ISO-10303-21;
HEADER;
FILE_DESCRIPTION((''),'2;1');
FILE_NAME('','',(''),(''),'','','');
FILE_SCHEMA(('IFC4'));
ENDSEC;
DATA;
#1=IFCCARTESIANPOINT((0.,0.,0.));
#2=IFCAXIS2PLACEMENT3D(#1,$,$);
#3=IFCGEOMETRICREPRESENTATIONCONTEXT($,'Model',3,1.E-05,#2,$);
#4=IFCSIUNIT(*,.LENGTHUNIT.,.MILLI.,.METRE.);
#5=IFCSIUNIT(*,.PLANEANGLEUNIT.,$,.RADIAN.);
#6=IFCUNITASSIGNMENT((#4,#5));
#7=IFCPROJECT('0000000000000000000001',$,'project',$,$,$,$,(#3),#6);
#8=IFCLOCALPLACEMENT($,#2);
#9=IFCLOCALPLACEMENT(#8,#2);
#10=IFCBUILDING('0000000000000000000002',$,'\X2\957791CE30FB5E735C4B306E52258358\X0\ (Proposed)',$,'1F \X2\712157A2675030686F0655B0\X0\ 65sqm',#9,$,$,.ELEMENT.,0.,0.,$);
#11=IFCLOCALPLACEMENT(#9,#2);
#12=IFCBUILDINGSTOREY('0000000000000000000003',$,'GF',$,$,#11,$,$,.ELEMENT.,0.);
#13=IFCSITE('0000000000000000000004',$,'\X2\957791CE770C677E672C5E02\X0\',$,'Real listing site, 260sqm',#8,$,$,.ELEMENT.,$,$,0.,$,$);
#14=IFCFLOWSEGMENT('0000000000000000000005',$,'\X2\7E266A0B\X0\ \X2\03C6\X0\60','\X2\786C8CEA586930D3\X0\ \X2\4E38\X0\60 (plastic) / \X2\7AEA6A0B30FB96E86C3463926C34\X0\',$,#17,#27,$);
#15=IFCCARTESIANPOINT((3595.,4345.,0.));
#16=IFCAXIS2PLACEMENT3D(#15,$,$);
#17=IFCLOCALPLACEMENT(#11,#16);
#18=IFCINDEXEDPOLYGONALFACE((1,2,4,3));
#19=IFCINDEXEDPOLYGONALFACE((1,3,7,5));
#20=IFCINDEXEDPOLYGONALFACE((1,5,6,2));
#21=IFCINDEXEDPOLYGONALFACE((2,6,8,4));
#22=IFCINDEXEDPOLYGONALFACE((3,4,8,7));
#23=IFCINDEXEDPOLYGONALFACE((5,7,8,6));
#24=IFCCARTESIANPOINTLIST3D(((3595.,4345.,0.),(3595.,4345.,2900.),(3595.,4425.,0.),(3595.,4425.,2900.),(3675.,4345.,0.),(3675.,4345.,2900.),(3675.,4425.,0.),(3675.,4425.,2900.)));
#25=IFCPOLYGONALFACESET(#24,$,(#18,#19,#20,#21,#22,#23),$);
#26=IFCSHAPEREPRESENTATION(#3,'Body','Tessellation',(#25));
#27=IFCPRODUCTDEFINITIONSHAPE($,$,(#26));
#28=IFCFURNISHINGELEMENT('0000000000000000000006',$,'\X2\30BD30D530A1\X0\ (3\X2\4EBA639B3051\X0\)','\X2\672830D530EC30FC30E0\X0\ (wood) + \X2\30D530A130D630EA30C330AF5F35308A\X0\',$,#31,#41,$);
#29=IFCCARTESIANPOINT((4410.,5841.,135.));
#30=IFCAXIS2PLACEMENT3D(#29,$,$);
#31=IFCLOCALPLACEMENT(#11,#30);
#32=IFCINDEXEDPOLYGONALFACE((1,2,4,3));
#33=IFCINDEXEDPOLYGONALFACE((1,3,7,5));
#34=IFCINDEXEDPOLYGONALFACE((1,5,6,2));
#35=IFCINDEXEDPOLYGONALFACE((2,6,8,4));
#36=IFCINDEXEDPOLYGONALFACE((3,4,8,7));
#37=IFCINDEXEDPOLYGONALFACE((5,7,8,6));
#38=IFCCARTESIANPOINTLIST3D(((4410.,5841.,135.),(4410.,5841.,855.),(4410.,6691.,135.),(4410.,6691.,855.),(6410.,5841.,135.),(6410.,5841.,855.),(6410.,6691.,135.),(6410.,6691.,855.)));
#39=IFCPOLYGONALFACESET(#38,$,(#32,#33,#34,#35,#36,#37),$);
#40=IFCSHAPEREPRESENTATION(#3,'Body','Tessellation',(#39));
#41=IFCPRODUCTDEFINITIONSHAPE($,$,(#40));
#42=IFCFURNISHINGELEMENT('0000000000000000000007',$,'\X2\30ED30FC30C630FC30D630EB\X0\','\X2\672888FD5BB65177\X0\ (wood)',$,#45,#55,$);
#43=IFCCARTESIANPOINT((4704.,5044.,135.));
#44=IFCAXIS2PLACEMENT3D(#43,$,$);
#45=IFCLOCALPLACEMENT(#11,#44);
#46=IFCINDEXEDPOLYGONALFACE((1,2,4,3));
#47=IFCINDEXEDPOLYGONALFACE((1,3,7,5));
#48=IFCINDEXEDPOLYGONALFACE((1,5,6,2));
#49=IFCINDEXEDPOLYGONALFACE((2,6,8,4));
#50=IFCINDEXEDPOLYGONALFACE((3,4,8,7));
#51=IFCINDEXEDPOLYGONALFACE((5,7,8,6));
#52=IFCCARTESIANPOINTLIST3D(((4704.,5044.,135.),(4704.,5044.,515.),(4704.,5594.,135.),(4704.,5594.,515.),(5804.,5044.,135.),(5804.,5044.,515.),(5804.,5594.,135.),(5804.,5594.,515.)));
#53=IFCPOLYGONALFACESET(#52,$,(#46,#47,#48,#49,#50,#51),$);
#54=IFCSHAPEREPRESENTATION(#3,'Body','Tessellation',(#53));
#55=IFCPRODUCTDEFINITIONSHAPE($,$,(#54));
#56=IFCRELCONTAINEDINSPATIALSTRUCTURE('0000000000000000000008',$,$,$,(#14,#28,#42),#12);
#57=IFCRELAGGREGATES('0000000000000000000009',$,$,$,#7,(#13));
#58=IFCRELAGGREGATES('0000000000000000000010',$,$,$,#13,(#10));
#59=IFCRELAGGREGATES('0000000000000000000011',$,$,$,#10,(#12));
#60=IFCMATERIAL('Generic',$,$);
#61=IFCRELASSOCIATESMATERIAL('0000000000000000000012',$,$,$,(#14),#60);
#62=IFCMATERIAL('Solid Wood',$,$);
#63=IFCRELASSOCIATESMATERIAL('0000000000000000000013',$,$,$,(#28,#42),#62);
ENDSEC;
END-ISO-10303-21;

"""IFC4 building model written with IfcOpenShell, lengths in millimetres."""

from ifc_helpers import new_model, si_unit, frame, frame_2d, origin, place, context, project, spatial, rectangle, extrude, material, element, save


model = new_model("IFC4")

# Units and contexts
model_context = context("Model", 3, precision=1e-05, world=origin())
ifc_project = project(units=[si_unit("LENGTHUNIT", "METRE", prefix="MILLI"), si_unit("PLANEANGLEUNIT", "RADIAN")], contexts=[model_context])

# Site, building, storey
site_placement = place(None, origin())
site = spatial("IfcSite", under=ifc_project, at=site_placement, Name="長野県松本市", ObjectType="Real listing site, 260sqm", CompositionType="ELEMENT", RefElevation=0.0)
building_placement = place(site_placement, origin())
building = spatial("IfcBuilding", under=site, at=building_placement, Name="長野・平屋の別荘 (Proposed)", ObjectType="1F 無垢材と漆喰 65sqm", CompositionType="ELEMENT", ElevationOfRefHeight=0.0, ElevationOfTerrain=0.0)
storey_placement = place(building_placement, origin())
storey = spatial("IfcBuildingStorey", under=building, at=storey_placement, Name="GF", CompositionType="ELEMENT", Elevation=0.0)

# Shared definitions
ifc_material_1 = material(Name="Solid Wood")

# Shared definitions
ifc_material_2 = material(Name="Generic")

# Flow segment
flow_segment_1_placement = place(storey_placement, frame((3595.0, 4345.0, 0.0)))
element("IfcFlowSegment", 1, at=flow_segment_1_placement, inside=storey, material=ifc_material_2, Name="縦樋 φ60", Description="硬質塩ビ 丸60 (plastic) / 竪樋・雨水排水", context=model_context, shape_type="SweptSolid", body=[
    extrude(rectangle(XDim=80.0, YDim=80.0, at=frame_2d((40.0, 40.0))), frame((3595.0, 4345.0, 0.0)), (0.0, 0.0, 1.0), 2900.0),
])

# Furnishing elements
furnishing_1_placement = place(storey_placement, frame((4410.0, 5841.0, 135.0)))
element("IfcFurnishingElement", 2, at=furnishing_1_placement, inside=storey, material=ifc_material_1, Name="ソファ (3人掛け)", Description="木フレーム (wood) + ファブリック張り", context=model_context, shape_type="SweptSolid", body=[
    extrude(rectangle(XDim=2000.0, YDim=850.0, at=frame_2d((1000.0, 425.0))), frame((4410.0, 5841.0, 135.0)), (0.0, 0.0, 1.0), 720.0),
])
furnishing_2_placement = place(storey_placement, frame((4704.0, 5044.0, 135.0)))
element("IfcFurnishingElement", 3, at=furnishing_2_placement, inside=storey, material=ifc_material_1, Name="ローテーブル", Description="木製家具 (wood)", context=model_context, shape_type="SweptSolid", body=[
    extrude(rectangle(XDim=1100.0, YDim=550.0, at=frame_2d((550.0, 275.0))), frame((4704.0, 5044.0, 135.0)), (0.0, 0.0, 1.0), 380.0),
])

save(model, "model.ifc")
